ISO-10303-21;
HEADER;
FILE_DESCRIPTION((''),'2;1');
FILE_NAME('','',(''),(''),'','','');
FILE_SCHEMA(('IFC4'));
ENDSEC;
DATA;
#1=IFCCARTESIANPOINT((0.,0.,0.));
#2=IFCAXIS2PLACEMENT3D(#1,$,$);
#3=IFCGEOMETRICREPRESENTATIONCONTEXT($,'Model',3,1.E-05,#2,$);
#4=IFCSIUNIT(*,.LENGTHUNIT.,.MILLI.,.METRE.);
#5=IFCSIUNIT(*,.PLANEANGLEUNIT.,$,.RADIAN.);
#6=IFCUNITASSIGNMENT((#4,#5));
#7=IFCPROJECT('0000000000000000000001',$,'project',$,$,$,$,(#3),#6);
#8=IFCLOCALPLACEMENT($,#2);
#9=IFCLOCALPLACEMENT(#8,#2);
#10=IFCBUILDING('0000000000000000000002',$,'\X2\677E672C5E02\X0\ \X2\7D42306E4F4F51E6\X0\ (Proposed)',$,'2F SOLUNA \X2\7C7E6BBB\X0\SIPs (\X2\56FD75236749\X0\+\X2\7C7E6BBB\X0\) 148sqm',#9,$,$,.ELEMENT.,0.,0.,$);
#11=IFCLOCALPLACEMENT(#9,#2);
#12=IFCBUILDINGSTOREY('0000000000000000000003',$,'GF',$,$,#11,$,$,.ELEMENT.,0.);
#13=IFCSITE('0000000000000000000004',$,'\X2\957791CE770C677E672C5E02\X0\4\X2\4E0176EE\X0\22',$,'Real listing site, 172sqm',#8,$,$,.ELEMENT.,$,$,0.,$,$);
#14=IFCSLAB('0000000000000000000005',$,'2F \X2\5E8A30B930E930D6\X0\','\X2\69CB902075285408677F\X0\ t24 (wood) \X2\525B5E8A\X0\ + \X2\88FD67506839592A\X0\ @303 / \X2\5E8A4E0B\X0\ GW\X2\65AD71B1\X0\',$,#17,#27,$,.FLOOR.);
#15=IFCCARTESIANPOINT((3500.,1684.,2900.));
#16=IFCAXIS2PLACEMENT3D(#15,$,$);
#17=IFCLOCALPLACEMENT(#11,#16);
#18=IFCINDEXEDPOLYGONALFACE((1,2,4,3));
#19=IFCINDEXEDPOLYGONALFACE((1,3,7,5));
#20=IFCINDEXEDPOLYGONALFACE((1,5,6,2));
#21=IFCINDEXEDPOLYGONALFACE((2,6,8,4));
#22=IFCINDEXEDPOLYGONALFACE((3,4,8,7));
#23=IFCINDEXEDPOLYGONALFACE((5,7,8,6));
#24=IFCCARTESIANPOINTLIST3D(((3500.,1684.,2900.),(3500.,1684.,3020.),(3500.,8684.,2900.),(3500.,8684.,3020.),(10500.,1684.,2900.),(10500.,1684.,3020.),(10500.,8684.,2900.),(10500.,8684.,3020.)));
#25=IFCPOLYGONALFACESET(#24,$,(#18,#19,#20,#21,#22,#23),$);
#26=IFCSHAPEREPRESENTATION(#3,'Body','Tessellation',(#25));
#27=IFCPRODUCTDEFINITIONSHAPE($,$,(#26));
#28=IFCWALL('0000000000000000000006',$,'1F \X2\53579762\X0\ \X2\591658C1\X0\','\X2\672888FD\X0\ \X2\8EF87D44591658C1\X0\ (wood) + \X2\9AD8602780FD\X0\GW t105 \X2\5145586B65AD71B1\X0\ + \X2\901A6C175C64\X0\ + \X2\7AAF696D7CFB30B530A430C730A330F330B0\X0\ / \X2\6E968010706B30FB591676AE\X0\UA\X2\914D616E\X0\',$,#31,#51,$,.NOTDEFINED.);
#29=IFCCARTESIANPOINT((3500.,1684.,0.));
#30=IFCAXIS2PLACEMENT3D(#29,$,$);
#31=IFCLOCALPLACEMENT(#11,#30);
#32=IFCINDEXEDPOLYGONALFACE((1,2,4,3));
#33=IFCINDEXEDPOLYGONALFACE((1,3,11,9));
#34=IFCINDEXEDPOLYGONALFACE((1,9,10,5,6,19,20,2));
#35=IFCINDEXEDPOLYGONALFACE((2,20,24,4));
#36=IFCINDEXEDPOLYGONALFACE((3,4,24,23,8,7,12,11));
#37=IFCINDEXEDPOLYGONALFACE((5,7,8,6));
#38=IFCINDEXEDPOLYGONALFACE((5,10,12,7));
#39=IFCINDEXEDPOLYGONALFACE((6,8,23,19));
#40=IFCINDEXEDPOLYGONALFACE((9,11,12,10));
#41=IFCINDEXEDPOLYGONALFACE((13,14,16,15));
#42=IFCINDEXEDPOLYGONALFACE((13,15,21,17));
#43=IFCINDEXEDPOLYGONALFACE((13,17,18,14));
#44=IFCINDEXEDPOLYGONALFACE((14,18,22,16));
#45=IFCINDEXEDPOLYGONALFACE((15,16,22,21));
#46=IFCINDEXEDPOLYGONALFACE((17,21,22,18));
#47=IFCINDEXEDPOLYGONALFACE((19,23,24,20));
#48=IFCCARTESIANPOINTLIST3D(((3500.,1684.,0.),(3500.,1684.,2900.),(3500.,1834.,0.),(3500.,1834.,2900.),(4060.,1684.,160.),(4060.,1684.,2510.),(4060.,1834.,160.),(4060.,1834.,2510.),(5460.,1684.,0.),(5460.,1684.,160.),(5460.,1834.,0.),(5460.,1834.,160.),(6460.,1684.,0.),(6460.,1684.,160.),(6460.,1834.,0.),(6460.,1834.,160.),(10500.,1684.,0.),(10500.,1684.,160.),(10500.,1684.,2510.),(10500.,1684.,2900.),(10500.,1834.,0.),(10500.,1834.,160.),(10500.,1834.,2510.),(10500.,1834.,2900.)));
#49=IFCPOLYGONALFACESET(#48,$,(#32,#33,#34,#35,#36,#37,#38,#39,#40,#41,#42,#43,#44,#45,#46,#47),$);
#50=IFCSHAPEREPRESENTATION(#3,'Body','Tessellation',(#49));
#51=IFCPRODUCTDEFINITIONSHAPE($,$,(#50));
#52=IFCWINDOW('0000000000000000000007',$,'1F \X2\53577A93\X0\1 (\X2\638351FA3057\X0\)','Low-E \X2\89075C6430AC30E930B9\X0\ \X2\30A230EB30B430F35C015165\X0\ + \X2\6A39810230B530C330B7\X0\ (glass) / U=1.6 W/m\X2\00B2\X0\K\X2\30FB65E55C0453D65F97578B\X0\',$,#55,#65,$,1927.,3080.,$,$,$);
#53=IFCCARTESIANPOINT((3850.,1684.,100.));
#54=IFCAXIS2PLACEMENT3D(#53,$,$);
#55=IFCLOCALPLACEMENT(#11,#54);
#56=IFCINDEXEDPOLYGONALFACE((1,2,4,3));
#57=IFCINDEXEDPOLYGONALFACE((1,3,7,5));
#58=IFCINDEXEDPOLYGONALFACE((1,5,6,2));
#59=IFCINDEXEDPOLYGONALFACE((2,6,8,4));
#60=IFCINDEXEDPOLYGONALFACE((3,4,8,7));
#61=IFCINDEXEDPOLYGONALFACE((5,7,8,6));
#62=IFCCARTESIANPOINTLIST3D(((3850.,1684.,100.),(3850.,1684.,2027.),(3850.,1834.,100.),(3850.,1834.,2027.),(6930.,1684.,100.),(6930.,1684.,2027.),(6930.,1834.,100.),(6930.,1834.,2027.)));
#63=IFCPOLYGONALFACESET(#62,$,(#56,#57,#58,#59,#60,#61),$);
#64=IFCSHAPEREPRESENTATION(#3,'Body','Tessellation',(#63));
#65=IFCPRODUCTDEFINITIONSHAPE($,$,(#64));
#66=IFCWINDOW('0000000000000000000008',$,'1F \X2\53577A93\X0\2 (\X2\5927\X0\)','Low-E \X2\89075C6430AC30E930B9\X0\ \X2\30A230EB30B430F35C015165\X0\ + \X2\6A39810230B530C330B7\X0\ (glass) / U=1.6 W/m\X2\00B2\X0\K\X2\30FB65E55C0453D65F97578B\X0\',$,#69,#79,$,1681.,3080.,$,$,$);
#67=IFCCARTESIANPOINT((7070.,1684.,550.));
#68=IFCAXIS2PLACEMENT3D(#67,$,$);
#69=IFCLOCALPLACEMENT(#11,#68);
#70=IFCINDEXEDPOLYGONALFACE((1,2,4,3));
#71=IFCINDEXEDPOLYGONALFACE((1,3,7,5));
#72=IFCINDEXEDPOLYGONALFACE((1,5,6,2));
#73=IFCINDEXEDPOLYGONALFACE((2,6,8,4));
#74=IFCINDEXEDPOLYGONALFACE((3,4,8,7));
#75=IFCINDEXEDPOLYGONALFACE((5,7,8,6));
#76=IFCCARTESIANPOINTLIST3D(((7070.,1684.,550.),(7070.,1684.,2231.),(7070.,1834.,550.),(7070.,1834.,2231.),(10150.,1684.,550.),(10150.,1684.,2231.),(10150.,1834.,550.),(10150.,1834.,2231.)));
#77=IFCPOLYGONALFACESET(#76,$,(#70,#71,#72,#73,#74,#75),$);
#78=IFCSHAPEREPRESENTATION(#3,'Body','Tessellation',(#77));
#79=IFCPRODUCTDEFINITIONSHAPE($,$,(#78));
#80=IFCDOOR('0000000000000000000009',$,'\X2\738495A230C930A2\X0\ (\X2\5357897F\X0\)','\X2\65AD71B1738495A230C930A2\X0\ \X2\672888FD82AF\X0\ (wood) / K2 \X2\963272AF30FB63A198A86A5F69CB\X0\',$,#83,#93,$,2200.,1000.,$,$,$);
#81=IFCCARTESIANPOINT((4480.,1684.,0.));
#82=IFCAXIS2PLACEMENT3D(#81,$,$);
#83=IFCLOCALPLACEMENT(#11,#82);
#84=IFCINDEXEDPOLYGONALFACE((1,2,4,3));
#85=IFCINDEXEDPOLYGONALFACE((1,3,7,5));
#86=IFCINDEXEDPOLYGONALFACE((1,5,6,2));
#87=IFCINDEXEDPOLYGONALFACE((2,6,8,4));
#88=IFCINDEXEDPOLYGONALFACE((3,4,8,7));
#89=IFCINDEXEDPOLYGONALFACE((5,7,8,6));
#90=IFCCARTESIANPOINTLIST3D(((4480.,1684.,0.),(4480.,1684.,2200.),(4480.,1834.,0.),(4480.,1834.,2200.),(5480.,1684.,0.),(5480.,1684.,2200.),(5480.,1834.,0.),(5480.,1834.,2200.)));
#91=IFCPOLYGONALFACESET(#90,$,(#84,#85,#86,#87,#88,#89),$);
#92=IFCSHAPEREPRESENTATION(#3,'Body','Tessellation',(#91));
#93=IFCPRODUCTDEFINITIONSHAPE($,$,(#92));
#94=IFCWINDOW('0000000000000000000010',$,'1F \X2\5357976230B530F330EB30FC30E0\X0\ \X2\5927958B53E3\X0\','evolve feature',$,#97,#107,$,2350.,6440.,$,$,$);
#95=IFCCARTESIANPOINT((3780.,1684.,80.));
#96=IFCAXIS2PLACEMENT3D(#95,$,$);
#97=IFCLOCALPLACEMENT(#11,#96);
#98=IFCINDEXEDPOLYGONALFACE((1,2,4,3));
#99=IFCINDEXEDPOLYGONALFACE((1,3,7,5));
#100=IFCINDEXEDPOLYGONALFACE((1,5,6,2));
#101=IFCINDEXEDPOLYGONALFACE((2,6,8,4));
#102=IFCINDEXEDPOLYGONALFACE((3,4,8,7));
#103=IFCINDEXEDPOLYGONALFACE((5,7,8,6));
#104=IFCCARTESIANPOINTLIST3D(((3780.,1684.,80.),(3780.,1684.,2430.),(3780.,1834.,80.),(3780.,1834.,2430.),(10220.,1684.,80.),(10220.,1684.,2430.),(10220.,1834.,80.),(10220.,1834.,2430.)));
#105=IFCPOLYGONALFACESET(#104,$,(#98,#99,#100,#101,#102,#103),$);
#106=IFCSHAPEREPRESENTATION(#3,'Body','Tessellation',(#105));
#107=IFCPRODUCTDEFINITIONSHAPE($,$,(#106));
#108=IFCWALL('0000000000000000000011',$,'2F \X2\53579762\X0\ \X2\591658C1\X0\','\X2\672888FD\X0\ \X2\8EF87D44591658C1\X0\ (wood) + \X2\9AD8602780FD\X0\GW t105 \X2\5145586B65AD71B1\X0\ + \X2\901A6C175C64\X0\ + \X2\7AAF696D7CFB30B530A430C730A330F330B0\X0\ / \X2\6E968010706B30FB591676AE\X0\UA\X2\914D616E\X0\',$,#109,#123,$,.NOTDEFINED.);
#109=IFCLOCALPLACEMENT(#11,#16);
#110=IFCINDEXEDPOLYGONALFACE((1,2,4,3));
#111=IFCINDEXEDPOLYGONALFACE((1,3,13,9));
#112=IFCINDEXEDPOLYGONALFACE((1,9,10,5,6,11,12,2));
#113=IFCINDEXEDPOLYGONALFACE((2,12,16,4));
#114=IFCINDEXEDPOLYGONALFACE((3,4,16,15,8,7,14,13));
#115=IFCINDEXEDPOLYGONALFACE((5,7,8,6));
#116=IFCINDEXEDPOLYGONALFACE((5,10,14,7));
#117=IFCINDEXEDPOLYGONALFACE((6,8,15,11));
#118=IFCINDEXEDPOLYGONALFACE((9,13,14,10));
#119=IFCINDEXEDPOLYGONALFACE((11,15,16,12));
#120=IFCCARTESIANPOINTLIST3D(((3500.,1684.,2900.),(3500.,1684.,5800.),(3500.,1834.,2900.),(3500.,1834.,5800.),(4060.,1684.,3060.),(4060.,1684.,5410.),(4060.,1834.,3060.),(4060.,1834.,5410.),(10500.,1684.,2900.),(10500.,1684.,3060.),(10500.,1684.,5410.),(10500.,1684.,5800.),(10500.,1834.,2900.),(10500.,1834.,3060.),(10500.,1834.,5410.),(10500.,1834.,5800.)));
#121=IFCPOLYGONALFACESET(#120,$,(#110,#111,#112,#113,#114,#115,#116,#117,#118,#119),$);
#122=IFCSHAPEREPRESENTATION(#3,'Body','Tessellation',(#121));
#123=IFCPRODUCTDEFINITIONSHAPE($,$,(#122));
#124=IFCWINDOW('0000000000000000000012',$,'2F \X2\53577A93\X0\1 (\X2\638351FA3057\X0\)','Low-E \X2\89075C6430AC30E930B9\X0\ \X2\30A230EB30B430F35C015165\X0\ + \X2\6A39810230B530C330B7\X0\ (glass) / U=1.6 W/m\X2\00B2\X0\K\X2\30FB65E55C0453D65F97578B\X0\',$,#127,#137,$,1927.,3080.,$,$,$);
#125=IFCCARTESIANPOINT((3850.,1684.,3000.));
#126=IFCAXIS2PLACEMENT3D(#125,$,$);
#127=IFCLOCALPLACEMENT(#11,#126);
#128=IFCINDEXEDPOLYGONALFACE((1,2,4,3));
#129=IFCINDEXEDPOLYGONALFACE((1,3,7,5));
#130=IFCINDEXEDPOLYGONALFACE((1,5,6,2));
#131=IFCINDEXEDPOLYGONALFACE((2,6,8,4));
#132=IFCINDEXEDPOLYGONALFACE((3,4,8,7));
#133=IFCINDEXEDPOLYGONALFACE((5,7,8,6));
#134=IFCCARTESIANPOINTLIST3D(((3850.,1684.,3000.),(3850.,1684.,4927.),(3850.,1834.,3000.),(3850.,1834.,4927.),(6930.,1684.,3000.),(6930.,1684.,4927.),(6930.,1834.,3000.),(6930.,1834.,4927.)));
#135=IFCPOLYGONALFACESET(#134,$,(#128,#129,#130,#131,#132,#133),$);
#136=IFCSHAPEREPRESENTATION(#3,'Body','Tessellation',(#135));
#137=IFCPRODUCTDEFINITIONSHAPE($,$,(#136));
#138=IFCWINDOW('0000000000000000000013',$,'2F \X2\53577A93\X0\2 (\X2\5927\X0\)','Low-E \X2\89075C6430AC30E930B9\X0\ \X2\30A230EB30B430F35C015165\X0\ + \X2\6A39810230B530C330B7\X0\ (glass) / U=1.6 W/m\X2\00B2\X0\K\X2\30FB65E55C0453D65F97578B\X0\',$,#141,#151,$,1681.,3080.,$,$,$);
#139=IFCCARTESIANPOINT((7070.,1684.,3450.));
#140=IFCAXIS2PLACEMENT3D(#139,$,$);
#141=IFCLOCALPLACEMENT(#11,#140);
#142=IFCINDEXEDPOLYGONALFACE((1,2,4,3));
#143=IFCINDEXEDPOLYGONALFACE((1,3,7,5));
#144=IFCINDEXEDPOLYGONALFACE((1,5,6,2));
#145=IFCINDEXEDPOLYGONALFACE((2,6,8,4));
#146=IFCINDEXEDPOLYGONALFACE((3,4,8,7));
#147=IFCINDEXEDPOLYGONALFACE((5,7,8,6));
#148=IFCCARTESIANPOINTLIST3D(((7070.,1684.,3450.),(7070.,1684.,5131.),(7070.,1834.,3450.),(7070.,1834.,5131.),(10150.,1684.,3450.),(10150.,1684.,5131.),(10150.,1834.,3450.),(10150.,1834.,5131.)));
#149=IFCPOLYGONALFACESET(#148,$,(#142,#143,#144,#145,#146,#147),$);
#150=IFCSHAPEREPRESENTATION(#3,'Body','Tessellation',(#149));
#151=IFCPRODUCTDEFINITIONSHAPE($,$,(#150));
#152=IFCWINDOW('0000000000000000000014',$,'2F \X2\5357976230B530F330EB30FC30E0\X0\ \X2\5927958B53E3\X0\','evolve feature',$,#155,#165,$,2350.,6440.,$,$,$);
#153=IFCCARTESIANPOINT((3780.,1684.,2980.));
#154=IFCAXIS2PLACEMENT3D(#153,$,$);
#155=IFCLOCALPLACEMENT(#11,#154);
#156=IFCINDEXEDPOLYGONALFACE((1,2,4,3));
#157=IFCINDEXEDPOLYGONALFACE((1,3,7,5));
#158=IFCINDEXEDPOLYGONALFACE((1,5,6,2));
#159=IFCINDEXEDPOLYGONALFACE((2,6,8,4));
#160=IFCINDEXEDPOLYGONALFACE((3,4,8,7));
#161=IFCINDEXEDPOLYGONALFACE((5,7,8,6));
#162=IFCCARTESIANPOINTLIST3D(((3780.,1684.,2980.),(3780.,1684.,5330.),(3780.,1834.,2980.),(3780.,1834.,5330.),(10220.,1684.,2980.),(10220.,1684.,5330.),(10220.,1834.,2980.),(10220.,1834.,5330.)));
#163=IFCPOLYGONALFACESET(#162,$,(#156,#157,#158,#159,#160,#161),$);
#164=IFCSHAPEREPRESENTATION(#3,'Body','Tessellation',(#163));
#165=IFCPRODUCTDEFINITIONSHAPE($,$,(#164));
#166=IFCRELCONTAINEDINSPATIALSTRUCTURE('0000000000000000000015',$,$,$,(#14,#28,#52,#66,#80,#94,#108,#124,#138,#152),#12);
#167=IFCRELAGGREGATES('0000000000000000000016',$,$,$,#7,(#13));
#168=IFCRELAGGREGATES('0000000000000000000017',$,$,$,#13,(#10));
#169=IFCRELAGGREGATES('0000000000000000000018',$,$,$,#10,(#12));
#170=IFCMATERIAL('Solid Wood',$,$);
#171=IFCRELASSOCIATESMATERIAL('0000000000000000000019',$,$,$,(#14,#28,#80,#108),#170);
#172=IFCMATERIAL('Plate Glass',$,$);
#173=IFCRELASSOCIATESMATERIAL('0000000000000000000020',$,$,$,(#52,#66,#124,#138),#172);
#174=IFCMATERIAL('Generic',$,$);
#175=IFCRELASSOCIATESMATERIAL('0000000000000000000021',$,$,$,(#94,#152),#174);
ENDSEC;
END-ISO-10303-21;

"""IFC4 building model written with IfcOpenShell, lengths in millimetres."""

from ifc_helpers import new_model, si_unit, frame, frame_2d, origin, place, context, project, spatial, rectangle, extrude, material, element, fill, save


model = new_model("IFC4")

# Units and contexts
model_context = context("Model", 3, precision=1e-05, world=origin())
ifc_project = project(units=[si_unit("LENGTHUNIT", "METRE", prefix="MILLI"), si_unit("PLANEANGLEUNIT", "RADIAN")], contexts=[model_context])

# Site, building, storey
site_placement = place(None, origin())
site = spatial("IfcSite", under=ifc_project, at=site_placement, Name="長野県松本市4丁目22", ObjectType="Real listing site, 172sqm", CompositionType="ELEMENT", RefElevation=0.0)
building_placement = place(site_placement, origin())
building = spatial("IfcBuilding", under=site, at=building_placement, Name="松本市 終の住処 (Proposed)", ObjectType="2F SOLUNA 籾殻SIPs (国産杉+籾殻) 148sqm", CompositionType="ELEMENT", ElevationOfRefHeight=0.0, ElevationOfTerrain=0.0)
storey_placement = place(building_placement, origin())
storey = spatial("IfcBuildingStorey", under=building, at=storey_placement, Name="GF", CompositionType="ELEMENT", Elevation=0.0)

# Slab
ifc_material_1 = material(Name="Solid Wood")
slab_1_placement = place(storey_placement, frame((3500.0, 1684.0, 2900.0)))
element("IfcSlab", 1, at=slab_1_placement, inside=storey, material=ifc_material_1, Name="2F 床スラブ", Description="構造用合板 t24 (wood) 剛床 + 製材根太 @303 / 床下 GW断熱", PredefinedType="FLOOR", context=model_context, shape_type="SweptSolid", body=[
    extrude(rectangle(XDim=7000.0, YDim=7000.0, at=frame_2d((3500.0, 3500.0))), frame((3500.0, 1684.0, 2900.0)), (0.0, 0.0, 1.0), 120.0),
])
ifc_material_2 = material(Name="Generic")

# Wall, openings, windows, door
wall_1_placement = place(storey_placement, frame((3500.0, 1684.0, 0.0)))
wall_1 = element("IfcWall", 2, at=wall_1_placement, inside=storey, material=ifc_material_1, Name="1F 南面 外壁", Description="木製 軸組外壁 (wood) + 高性能GW t105 充填断熱 + 通気層 + 窯業系サイディング / 準耐火・外皮UA配慮", PredefinedType="NOTDEFINED", context=model_context, shape_type="SweptSolid", body=[
    extrude(rectangle(XDim=7000.0, YDim=150.0, at=frame_2d((3500.0, 75.0))), frame((3500.0, 1684.0, 0.0)), (0.0, 0.0, 1.0), 2900.0),
])
opening_1_placement = place(storey_placement, frame((3850.0, 1684.0, 100.0)))
opening_1 = element("IfcOpeningElement", 3, at=opening_1_placement, cuts=wall_1, PredefinedType="NOTDEFINED", context=model_context, shape_type="SweptSolid", body=[
    extrude(rectangle(XDim=3080.0, YDim=150.0, at=frame_2d((1540.0, 75.0))), frame((3850.0, 1684.0, 100.0)), (0.0, 0.0, 1.0), 1927.0),
])
opening_2_placement = place(storey_placement, frame((7070.0, 1684.0, 550.0)))
opening_2 = element("IfcOpeningElement", 4, at=opening_2_placement, cuts=wall_1, PredefinedType="NOTDEFINED", context=model_context, shape_type="SweptSolid", body=[
    extrude(rectangle(XDim=3080.0, YDim=150.0, at=frame_2d((1540.0, 75.0))), frame((7070.0, 1684.0, 550.0)), (0.0, 0.0, 1.0), 1681.0),
])
opening_3_placement = place(storey_placement, frame((4480.0, 1684.0, 0.0)))
opening_3 = element("IfcOpeningElement", 5, at=opening_3_placement, cuts=wall_1, PredefinedType="NOTDEFINED", context=model_context, shape_type="SweptSolid", body=[
    extrude(rectangle(XDim=1000.0, YDim=150.0, at=frame_2d((500.0, 75.0))), frame((4480.0, 1684.0, 0.0)), (0.0, 0.0, 1.0), 2200.0),
])
opening_4_placement = place(storey_placement, frame((3780.0, 1684.0, 80.0)))
opening_4 = element("IfcOpeningElement", 6, at=opening_4_placement, cuts=wall_1, PredefinedType="NOTDEFINED", context=model_context, shape_type="SweptSolid", body=[
    extrude(rectangle(XDim=6440.0, YDim=150.0, at=frame_2d((3220.0, 75.0))), frame((3780.0, 1684.0, 80.0)), (0.0, 0.0, 1.0), 2350.0),
])
ifc_material_3 = material(Name="Plate Glass")
window_1_placement = place(storey_placement, frame((3850.0, 1684.0, 100.0)))
window_1 = element("IfcWindow", 7, at=window_1_placement, inside=storey, material=ifc_material_3, Name="1F 南窓1 (掃出し)", Description="Low-E 複層ガラス アルゴン封入 + 樹脂サッシ (glass) / U=1.6 W/m²K・日射取得型", OverallHeight=1927.0, OverallWidth=3080.0, context=model_context, shape_type="SweptSolid", body=[
    extrude(rectangle(XDim=3080.0, YDim=150.0, at=frame_2d((1540.0, 75.0))), frame((3850.0, 1684.0, 100.0)), (0.0, 0.0, 1.0), 1927.0),
])
fill(opening_1, window_1)
window_2_placement = place(storey_placement, frame((7070.0, 1684.0, 550.0)))
window_2 = element("IfcWindow", 8, at=window_2_placement, inside=storey, material=ifc_material_3, Name="1F 南窓2 (大)", Description="Low-E 複層ガラス アルゴン封入 + 樹脂サッシ (glass) / U=1.6 W/m²K・日射取得型", OverallHeight=1681.0, OverallWidth=3080.0, context=model_context, shape_type="SweptSolid", body=[
    extrude(rectangle(XDim=3080.0, YDim=150.0, at=frame_2d((1540.0, 75.0))), frame((7070.0, 1684.0, 550.0)), (0.0, 0.0, 1.0), 1681.0),
])
fill(opening_2, window_2)
door_placement = place(storey_placement, frame((4480.0, 1684.0, 0.0)))
door = element("IfcDoor", 9, at=door_placement, inside=storey, material=ifc_material_1, Name="玄関ドア (南西)", Description="断熱玄関ドア 木製芯 (wood) / K2 防犯・採風機構", OverallHeight=2200.0, OverallWidth=1000.0, context=model_context, shape_type="SweptSolid", body=[
    extrude(rectangle(XDim=1000.0, YDim=150.0, at=frame_2d((500.0, 75.0))), frame((4480.0, 1684.0, 0.0)), (0.0, 0.0, 1.0), 2200.0),
])
fill(opening_3, door)
window_3_placement = place(storey_placement, frame((3780.0, 1684.0, 80.0)))
window_3 = element("IfcWindow", 10, at=window_3_placement, inside=storey, material=ifc_material_2, Name="1F 南面サンルーム 大開口", Description="evolve feature", OverallHeight=2350.0, OverallWidth=6440.0, context=model_context, shape_type="SweptSolid", body=[
    extrude(rectangle(XDim=6440.0, YDim=150.0, at=frame_2d((3220.0, 75.0))), frame((3780.0, 1684.0, 80.0)), (0.0, 0.0, 1.0), 2350.0),
])
fill(opening_4, window_3)

# Wall, openings, windows
wall_2_placement = place(storey_placement, frame((3500.0, 1684.0, 2900.0)))
wall_2 = element("IfcWall", 11, at=wall_2_placement, inside=storey, material=ifc_material_1, Name="2F 南面 外壁", Description="木製 軸組外壁 (wood) + 高性能GW t105 充填断熱 + 通気層 + 窯業系サイディング / 準耐火・外皮UA配慮", PredefinedType="NOTDEFINED", context=model_context, shape_type="SweptSolid", body=[
    extrude(rectangle(XDim=7000.0, YDim=150.0, at=frame_2d((3500.0, 75.0))), frame((3500.0, 1684.0, 2900.0)), (0.0, 0.0, 1.0), 2900.0),
])
opening_5_placement = place(storey_placement, frame((3850.0, 1684.0, 3000.0)))
opening_5 = element("IfcOpeningElement", 12, at=opening_5_placement, cuts=wall_2, PredefinedType="NOTDEFINED", context=model_context, shape_type="SweptSolid", body=[
    extrude(rectangle(XDim=3080.0, YDim=150.0, at=frame_2d((1540.0, 75.0))), frame((3850.0, 1684.0, 3000.0)), (0.0, 0.0, 1.0), 1927.0),
])
opening_6_placement = place(storey_placement, frame((7070.0, 1684.0, 3450.0)))
opening_6 = element("IfcOpeningElement", 13, at=opening_6_placement, cuts=wall_2, PredefinedType="NOTDEFINED", context=model_context, shape_type="SweptSolid", body=[
    extrude(rectangle(XDim=3080.0, YDim=150.0, at=frame_2d((1540.0, 75.0))), frame((7070.0, 1684.0, 3450.0)), (0.0, 0.0, 1.0), 1681.0),
])
opening_7_placement = place(storey_placement, frame((3780.0, 1684.0, 2980.0)))
opening_7 = element("IfcOpeningElement", 14, at=opening_7_placement, cuts=wall_2, PredefinedType="NOTDEFINED", context=model_context, shape_type="SweptSolid", body=[
    extrude(rectangle(XDim=6440.0, YDim=150.0, at=frame_2d((3220.0, 75.0))), frame((3780.0, 1684.0, 2980.0)), (0.0, 0.0, 1.0), 2350.0),
])
window_4_placement = place(storey_placement, frame((3850.0, 1684.0, 3000.0)))
window_4 = element("IfcWindow", 15, at=window_4_placement, inside=storey, material=ifc_material_3, Name="2F 南窓1 (掃出し)", Description="Low-E 複層ガラス アルゴン封入 + 樹脂サッシ (glass) / U=1.6 W/m²K・日射取得型", OverallHeight=1927.0, OverallWidth=3080.0, context=model_context, shape_type="SweptSolid", body=[
    extrude(rectangle(XDim=3080.0, YDim=150.0, at=frame_2d((1540.0, 75.0))), frame((3850.0, 1684.0, 3000.0)), (0.0, 0.0, 1.0), 1927.0),
])
fill(opening_5, window_4)
window_5_placement = place(storey_placement, frame((7070.0, 1684.0, 3450.0)))
window_5 = element("IfcWindow", 16, at=window_5_placement, inside=storey, material=ifc_material_3, Name="2F 南窓2 (大)", Description="Low-E 複層ガラス アルゴン封入 + 樹脂サッシ (glass) / U=1.6 W/m²K・日射取得型", OverallHeight=1681.0, OverallWidth=3080.0, context=model_context, shape_type="SweptSolid", body=[
    extrude(rectangle(XDim=3080.0, YDim=150.0, at=frame_2d((1540.0, 75.0))), frame((7070.0, 1684.0, 3450.0)), (0.0, 0.0, 1.0), 1681.0),
])
fill(opening_6, window_5)
window_6_placement = place(storey_placement, frame((3780.0, 1684.0, 2980.0)))
window_6 = element("IfcWindow", 17, at=window_6_placement, inside=storey, material=ifc_material_2, Name="2F 南面サンルーム 大開口", Description="evolve feature", OverallHeight=2350.0, OverallWidth=6440.0, context=model_context, shape_type="SweptSolid", body=[
    extrude(rectangle(XDim=6440.0, YDim=150.0, at=frame_2d((3220.0, 75.0))), frame((3780.0, 1684.0, 2980.0)), (0.0, 0.0, 1.0), 2350.0),
])
fill(opening_7, window_6)

save(model, "model.ifc")
